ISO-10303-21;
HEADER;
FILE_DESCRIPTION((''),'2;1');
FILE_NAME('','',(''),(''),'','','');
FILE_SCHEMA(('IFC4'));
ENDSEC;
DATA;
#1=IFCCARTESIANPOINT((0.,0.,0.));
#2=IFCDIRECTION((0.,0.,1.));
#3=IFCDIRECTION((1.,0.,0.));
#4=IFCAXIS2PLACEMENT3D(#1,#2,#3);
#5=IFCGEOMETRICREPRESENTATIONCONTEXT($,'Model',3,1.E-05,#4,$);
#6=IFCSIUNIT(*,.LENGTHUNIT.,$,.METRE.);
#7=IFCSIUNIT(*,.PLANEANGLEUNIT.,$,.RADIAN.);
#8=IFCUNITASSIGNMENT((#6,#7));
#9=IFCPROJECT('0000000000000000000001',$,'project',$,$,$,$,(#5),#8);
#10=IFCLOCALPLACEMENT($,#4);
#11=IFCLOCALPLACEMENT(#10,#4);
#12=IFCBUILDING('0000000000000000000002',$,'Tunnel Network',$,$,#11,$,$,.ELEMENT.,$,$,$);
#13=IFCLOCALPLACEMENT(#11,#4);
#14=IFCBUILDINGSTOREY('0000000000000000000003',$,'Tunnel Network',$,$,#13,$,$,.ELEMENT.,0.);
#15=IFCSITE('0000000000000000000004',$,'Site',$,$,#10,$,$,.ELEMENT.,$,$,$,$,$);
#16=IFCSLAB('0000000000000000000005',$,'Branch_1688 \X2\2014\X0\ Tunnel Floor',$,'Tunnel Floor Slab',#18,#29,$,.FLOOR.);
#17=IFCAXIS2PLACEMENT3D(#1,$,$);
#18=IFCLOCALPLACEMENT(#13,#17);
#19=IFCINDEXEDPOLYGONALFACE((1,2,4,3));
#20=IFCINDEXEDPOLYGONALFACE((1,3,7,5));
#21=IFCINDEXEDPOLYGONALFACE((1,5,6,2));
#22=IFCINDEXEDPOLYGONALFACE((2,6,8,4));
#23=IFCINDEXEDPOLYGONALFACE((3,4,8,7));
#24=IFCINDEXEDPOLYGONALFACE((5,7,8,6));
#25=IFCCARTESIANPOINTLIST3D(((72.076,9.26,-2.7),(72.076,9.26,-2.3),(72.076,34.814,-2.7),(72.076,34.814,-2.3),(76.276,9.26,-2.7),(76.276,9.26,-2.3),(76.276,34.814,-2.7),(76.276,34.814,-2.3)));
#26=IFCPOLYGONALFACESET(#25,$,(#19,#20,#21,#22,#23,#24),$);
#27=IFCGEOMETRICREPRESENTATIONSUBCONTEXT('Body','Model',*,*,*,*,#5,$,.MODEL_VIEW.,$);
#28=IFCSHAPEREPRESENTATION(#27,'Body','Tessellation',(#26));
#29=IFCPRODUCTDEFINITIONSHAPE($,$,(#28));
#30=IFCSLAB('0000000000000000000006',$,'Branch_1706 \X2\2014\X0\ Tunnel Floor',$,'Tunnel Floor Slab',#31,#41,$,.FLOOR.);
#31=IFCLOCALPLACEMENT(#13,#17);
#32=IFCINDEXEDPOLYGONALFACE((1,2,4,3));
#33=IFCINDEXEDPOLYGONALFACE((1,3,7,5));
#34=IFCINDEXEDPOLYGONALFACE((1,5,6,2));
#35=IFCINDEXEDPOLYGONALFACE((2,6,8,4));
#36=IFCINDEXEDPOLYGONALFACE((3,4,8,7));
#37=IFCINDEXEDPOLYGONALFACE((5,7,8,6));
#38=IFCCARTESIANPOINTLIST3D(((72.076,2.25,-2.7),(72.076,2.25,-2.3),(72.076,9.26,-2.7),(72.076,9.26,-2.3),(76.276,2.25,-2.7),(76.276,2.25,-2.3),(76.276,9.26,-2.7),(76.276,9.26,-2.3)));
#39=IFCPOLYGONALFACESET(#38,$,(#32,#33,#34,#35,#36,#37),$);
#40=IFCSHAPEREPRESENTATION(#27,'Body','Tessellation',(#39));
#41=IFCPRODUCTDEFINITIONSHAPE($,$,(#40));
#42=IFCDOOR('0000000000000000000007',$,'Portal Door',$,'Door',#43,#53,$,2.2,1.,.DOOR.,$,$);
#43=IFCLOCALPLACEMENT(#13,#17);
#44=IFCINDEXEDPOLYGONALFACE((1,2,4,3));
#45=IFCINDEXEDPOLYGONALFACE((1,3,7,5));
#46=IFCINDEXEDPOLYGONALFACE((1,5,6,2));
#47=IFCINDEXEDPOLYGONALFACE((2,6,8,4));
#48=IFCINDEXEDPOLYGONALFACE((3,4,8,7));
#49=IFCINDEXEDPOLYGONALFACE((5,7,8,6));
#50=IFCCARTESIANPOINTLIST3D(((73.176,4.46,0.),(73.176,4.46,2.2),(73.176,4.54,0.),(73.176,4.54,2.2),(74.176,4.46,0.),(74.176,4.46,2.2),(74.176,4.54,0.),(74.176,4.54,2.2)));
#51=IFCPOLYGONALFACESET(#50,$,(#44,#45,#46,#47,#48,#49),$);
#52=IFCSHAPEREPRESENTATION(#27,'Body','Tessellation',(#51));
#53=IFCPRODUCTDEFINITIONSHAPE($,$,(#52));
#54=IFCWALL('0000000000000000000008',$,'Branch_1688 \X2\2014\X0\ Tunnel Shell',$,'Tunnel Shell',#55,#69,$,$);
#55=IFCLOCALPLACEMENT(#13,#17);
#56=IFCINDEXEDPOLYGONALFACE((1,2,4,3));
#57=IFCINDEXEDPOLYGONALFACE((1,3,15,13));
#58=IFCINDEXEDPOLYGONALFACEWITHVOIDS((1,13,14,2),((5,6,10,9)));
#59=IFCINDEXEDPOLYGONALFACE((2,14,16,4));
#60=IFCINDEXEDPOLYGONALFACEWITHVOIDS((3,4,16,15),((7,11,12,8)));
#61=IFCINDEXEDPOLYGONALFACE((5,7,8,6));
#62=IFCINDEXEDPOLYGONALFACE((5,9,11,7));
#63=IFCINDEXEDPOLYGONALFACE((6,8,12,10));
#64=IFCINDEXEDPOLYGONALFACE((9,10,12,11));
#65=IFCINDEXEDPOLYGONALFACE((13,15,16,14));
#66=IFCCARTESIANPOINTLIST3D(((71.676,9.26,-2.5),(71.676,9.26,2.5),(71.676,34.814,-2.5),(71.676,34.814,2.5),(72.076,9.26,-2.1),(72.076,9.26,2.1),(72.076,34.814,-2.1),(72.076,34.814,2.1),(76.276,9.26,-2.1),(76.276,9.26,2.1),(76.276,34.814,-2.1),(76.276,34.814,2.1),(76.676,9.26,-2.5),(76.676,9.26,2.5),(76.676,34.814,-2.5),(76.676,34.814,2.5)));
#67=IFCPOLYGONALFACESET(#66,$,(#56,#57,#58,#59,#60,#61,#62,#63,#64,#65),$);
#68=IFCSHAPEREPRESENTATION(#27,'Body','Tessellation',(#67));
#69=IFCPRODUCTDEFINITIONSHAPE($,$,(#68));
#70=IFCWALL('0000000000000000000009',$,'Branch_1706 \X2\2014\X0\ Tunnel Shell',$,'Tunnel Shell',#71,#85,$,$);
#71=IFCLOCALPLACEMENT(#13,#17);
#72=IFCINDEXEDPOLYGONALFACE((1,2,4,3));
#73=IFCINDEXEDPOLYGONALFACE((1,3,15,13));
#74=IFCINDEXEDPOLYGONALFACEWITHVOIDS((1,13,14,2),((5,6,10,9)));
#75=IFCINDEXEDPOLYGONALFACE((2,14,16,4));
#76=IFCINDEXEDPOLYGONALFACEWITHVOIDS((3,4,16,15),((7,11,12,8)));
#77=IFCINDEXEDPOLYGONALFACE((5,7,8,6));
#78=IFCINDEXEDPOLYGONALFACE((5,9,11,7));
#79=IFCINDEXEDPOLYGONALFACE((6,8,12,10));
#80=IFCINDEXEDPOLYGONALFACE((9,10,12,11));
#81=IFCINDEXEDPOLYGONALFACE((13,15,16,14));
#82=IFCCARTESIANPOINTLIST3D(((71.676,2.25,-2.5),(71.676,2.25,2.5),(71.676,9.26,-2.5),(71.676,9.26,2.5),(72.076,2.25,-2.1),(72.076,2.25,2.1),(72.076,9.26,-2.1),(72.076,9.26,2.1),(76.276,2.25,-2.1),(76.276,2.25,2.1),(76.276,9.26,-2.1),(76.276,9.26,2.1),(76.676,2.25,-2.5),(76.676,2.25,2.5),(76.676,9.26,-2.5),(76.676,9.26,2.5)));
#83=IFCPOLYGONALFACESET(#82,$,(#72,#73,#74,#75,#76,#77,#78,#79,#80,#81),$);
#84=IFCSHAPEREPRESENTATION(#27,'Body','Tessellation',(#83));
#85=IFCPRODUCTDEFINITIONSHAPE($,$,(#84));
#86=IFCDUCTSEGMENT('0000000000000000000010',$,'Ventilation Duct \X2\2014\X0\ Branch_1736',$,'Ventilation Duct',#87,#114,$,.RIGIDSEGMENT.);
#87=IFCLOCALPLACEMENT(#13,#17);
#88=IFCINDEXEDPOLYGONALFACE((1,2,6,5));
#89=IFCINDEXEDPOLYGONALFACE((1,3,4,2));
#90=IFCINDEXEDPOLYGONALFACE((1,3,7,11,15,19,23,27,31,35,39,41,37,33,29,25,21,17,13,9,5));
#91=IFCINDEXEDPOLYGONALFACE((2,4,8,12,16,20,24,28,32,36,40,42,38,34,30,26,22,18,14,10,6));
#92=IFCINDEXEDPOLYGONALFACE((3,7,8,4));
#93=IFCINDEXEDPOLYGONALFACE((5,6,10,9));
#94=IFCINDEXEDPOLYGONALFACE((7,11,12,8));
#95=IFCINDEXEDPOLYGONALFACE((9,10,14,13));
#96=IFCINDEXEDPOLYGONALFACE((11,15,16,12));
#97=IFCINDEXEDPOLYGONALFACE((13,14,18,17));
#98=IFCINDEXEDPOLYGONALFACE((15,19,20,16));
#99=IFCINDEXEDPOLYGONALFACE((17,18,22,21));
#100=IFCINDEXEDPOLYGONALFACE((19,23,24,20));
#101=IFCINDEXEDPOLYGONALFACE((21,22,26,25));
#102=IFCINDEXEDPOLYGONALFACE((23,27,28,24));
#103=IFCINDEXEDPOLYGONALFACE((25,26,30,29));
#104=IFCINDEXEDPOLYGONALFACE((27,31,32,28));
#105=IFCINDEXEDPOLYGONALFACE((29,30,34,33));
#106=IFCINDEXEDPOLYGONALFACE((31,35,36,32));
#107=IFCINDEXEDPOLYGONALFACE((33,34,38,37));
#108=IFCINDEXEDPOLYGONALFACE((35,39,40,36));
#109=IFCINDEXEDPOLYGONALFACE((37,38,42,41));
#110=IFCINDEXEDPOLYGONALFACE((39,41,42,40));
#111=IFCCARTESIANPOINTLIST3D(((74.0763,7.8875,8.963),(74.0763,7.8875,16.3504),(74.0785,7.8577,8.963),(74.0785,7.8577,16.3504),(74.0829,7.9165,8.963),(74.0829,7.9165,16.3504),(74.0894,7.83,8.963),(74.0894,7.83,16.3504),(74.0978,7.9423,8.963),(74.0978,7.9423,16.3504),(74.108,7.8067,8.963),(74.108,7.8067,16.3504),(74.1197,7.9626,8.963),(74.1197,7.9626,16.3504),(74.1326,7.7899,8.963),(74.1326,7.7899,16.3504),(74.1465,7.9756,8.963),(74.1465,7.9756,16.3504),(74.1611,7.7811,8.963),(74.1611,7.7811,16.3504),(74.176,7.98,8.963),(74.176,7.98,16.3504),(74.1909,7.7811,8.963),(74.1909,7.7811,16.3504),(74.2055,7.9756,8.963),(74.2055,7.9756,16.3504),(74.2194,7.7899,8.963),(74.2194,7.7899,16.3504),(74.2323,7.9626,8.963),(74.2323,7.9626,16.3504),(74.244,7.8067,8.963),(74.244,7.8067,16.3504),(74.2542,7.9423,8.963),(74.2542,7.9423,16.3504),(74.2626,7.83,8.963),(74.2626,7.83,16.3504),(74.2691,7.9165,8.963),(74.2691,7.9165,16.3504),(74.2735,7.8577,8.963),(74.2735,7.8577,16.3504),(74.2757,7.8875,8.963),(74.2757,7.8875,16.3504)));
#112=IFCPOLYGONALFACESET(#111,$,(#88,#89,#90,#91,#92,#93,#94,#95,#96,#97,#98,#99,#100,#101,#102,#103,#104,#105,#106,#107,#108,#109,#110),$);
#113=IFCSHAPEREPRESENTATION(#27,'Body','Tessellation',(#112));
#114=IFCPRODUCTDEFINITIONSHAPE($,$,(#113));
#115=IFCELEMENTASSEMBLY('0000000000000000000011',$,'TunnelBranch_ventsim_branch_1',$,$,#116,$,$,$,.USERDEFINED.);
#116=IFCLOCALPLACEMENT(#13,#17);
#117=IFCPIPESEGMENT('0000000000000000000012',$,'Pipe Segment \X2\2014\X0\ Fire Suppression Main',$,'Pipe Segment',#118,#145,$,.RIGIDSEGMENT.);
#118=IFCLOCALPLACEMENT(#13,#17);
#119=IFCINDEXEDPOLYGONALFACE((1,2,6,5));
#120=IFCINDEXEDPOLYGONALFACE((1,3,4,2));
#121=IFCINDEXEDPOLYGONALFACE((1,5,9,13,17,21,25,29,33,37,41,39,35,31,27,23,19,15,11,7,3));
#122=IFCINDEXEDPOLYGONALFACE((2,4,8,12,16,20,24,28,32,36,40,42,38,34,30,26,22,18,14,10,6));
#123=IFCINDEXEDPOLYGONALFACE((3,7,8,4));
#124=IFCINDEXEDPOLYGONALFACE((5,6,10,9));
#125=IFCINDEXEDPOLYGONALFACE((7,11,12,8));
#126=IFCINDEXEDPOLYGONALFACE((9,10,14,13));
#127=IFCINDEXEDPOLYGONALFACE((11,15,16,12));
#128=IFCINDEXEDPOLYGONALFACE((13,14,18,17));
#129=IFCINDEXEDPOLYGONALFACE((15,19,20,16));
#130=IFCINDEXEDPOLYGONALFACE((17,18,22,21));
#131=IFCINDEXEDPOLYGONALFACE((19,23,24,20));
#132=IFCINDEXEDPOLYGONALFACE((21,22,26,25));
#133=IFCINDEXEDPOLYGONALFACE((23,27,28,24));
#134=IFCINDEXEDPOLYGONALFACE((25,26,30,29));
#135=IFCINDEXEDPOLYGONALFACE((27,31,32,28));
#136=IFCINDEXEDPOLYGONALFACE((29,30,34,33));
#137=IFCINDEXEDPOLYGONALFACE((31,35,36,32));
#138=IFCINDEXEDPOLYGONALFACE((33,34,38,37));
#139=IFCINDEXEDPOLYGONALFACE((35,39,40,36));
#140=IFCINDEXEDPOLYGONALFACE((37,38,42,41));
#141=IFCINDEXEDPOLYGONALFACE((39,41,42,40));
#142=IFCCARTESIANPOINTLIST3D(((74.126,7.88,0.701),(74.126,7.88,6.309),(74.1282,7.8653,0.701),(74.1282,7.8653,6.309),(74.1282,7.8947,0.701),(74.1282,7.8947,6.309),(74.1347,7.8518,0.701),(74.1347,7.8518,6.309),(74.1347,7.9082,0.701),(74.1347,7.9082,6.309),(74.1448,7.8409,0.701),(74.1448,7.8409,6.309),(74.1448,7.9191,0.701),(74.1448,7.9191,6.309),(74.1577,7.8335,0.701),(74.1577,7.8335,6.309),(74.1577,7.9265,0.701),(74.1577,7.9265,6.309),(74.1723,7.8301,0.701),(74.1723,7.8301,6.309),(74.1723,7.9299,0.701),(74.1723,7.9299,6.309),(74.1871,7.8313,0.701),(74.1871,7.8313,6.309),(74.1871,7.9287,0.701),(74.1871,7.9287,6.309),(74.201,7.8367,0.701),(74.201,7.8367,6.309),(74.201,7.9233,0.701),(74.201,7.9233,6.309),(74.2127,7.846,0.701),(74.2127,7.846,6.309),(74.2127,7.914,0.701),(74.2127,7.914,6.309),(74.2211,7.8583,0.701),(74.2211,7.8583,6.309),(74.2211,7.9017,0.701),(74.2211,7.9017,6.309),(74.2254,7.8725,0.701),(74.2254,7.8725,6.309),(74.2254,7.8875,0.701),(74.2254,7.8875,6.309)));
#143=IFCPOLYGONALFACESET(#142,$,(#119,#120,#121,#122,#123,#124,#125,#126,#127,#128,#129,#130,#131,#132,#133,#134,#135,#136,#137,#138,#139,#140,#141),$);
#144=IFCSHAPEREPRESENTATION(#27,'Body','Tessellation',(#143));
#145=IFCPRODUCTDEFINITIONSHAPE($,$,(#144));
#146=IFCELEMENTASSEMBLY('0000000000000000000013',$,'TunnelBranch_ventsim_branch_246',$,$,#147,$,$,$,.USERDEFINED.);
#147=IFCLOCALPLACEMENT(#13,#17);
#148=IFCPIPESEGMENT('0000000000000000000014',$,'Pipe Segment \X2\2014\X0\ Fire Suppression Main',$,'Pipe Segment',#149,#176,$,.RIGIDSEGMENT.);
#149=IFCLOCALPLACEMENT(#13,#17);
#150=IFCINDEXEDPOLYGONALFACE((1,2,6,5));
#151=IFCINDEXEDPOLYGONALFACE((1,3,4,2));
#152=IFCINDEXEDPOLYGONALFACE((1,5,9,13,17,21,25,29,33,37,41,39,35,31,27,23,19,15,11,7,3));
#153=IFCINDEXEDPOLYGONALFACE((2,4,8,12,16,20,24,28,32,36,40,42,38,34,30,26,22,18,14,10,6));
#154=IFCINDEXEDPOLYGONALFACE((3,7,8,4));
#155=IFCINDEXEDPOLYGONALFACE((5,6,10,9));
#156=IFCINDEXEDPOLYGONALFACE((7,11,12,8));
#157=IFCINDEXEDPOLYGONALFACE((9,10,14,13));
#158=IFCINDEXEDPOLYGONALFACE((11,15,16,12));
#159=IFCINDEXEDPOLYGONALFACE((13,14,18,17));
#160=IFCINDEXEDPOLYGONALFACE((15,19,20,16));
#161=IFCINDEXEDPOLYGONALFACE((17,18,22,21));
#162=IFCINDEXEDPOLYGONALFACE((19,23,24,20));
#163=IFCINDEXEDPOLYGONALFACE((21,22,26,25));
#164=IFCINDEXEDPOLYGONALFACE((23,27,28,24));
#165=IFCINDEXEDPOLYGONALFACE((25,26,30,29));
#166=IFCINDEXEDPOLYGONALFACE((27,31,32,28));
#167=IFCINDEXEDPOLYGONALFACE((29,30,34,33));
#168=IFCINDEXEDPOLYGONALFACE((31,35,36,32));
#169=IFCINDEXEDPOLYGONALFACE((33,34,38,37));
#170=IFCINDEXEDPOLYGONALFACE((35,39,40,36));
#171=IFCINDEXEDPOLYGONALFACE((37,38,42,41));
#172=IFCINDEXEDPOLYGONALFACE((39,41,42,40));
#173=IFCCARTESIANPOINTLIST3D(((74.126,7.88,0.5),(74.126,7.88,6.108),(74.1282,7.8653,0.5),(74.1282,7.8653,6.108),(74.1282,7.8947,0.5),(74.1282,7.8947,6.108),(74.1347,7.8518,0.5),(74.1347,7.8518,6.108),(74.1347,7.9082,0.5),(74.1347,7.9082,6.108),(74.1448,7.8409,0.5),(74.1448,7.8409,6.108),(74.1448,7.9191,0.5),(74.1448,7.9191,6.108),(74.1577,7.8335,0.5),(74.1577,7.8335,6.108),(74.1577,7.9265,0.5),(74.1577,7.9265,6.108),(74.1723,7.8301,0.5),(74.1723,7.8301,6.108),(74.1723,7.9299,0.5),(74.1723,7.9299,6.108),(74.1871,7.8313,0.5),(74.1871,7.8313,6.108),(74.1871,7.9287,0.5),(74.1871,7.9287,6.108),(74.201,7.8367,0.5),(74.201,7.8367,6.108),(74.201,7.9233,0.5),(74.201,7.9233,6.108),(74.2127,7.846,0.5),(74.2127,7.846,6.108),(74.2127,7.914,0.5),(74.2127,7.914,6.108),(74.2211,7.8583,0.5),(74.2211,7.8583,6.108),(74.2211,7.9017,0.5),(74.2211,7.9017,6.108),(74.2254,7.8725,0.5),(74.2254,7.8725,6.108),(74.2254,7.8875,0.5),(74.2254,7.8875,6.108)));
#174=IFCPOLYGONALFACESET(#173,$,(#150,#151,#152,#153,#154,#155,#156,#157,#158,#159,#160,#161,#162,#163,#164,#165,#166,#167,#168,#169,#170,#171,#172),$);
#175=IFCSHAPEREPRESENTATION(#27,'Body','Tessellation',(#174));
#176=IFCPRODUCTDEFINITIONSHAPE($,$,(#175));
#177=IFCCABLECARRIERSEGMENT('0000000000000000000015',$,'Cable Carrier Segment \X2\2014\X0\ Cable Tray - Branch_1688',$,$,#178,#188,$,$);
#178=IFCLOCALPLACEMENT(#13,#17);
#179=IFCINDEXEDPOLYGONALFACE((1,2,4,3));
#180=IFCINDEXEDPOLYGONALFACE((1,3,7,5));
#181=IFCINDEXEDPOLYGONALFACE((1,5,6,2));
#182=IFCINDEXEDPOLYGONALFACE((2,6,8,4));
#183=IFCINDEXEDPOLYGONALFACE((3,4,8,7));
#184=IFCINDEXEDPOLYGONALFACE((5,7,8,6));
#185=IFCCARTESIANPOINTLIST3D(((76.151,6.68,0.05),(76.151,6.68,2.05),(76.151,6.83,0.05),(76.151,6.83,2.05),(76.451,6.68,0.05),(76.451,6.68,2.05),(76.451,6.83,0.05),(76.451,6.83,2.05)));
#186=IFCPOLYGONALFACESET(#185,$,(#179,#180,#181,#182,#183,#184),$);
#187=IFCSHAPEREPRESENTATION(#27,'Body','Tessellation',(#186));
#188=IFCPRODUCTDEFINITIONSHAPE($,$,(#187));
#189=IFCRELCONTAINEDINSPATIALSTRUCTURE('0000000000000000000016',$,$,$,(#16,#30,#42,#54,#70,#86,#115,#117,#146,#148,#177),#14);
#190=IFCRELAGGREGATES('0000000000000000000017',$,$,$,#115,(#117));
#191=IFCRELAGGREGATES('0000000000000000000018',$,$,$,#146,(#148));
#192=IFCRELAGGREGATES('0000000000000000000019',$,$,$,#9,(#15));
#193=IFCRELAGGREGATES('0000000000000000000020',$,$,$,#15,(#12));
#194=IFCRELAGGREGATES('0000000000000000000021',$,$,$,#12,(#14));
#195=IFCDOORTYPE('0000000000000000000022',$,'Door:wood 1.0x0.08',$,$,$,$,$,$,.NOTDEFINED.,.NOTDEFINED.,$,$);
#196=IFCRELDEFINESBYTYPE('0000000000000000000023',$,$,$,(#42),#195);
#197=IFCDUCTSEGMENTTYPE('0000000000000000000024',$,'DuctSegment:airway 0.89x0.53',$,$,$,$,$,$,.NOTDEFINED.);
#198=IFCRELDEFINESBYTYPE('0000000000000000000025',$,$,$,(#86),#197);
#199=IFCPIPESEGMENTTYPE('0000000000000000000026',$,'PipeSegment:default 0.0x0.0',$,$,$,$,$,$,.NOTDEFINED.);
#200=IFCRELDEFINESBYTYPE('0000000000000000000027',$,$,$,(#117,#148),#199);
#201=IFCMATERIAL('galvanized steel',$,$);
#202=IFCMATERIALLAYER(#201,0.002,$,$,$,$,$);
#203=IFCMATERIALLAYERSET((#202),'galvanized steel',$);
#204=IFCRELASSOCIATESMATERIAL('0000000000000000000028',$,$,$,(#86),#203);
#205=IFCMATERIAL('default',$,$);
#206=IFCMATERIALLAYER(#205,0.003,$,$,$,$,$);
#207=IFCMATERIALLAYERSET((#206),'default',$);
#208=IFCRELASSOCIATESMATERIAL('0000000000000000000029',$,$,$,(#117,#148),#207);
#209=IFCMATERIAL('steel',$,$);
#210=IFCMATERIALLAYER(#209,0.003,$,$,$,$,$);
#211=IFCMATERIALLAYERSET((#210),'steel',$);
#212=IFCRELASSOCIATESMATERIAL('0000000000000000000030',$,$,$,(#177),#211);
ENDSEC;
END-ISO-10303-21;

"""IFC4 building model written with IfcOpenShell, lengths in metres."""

from ifc_helpers import new_model, entity, si_unit, frame, origin_with_axes, origin_2d_with_axis, place, context, subcontext, project, spatial, rectangle, hollow_rectangle, circle, extrude, material, layer, layer_set, layer_usage, type_object, element, aggregate, save


model = new_model("IFC4")

# Units and contexts
model_context = context("Model", 3, precision=1e-05, world=origin_with_axes())
body_context = subcontext(model_context, "Body", "Model", "MODEL_VIEW")
ifc_project = project(units=[si_unit("LENGTHUNIT", "METRE"), si_unit("PLANEANGLEUNIT", "RADIAN")], contexts=[model_context])

# Site, building, storey
site_placement = place(None, origin_with_axes())
site = spatial("IfcSite", under=ifc_project, at=site_placement, Name="Site", CompositionType="ELEMENT")
building_placement = place(site_placement, origin_with_axes())
building = spatial("IfcBuilding", under=site, at=building_placement, Name="Tunnel Network", CompositionType="ELEMENT")
storey_placement = place(building_placement, origin_with_axes())
storey = spatial("IfcBuildingStorey", under=building, at=storey_placement, Name="Tunnel Network", CompositionType="ELEMENT", Elevation=0.0)

# Slabs
placement_1 = place(storey_placement, frame((74.176, 9.26, 0.0), z_axis=(0.0, 0.0, 1.0), x_axis=(0.0, 1.0, 0.0)))
element("IfcSlab", 1, at=placement_1, inside=storey, Name="Branch_1688 — Tunnel Floor", ObjectType="Tunnel Floor Slab", PredefinedType="FLOOR", context=body_context, shape_type="SweptSolid", body=[
    extrude(rectangle(XDim=0.4, YDim=4.2, at=origin_2d_with_axis()), frame((0.0, 0.0, -2.5), z_axis=(1.0, 0.0, 0.0), x_axis=(0.0, 0.0, 1.0)), (0.0, 0.0, 1.0), 25.554),
])
placement_2 = place(storey_placement, frame((74.176, 2.25, 0.0), z_axis=(0.0, 0.0, 1.0), x_axis=(0.0, 1.0, 0.0)))
element("IfcSlab", 2, at=placement_2, inside=storey, Name="Branch_1706 — Tunnel Floor", ObjectType="Tunnel Floor Slab", PredefinedType="FLOOR", context=body_context, shape_type="SweptSolid", body=[
    extrude(rectangle(XDim=0.4, YDim=4.2, at=origin_2d_with_axis()), frame((0.0, 0.0, -2.5), z_axis=(1.0, 0.0, 0.0), x_axis=(0.0, 0.0, 1.0)), (0.0, 0.0, 1.0), 7.01),
])

# Door
door_type = type_object("IfcDoorType", Name="Door:wood 1.0x0.08")
door_placement = place(storey_placement, frame((73.676, 4.5, 0.0), z_axis=(0.0, 0.0, 1.0), x_axis=(1.0, 0.0, 0.0)))
element("IfcDoor", 3, at=door_placement, inside=storey, type_object=door_type, Name="Portal Door", ObjectType="Door", OverallHeight=2.2, OverallWidth=1.0, PredefinedType="DOOR", context=body_context, shape_type="SweptSolid", body=[
    extrude(rectangle(XDim=1.0, YDim=0.08, at=origin_2d_with_axis()), origin_with_axes(), (0.0, 0.0, 1.0), 2.2),
])

# Walls
element("IfcWall", 4, at=placement_1, inside=storey, Name="Branch_1688 — Tunnel Shell", ObjectType="Tunnel Shell", context=body_context, shape_type="SweptSolid", body=[
    extrude(hollow_rectangle(XDim=5.0, YDim=5.0, WallThickness=0.4, at=origin_2d_with_axis()), frame((0.0, 0.0, 0.0), z_axis=(1.0, 0.0, 0.0), x_axis=(0.0, 0.0, 1.0)), (0.0, 0.0, 1.0), 25.554),
])
element("IfcWall", 5, at=placement_2, inside=storey, Name="Branch_1706 — Tunnel Shell", ObjectType="Tunnel Shell", context=body_context, shape_type="SweptSolid", body=[
    extrude(hollow_rectangle(XDim=5.0, YDim=5.0, WallThickness=0.4, at=origin_2d_with_axis()), frame((0.0, 0.0, 0.0), z_axis=(1.0, 0.0, 0.0), x_axis=(0.0, 0.0, 1.0)), (0.0, 0.0, 1.0), 7.01),
])

# Duct segment
ifc_material_1 = material(Name="galvanized steel")
ifc_layer_1 = layer(ifc_material_1, 0.002)
ifc_layer_set_1 = layer_set([ifc_layer_1], Name="galvanized steel")
ifc_layer_usage_1 = layer_usage(ifc_layer_set_1, "AXIS2", "POSITIVE", 0.0)
duct_segment_type = type_object("IfcDuctSegmentType", Name="DuctSegment:airway 0.89x0.53")
duct_segment_placement = place(storey_placement, frame((74.176, 7.88, 8.963), z_axis=(0.0, 0.0, 1.0), x_axis=(0.0, 1.0, 0.0)))
element("IfcDuctSegment", 6, at=duct_segment_placement, inside=storey, type_object=duct_segment_type, material=ifc_layer_usage_1, Name="Ventilation Duct — Branch_1736", ObjectType="Ventilation Duct", PredefinedType="RIGIDSEGMENT", context=body_context, shape_type="AdvancedSweptSolid", body=[
    entity("IfcSweptDiskSolid", entity("IfcPolyline", [entity("IfcCartesianPoint", [0.0, 0.0, 0.0]), entity("IfcCartesianPoint", [0.0, 0.0, 7.3874])]), 0.1),
])

# Element assemblies, pipe segments
assembly_1_placement = place(storey_placement, frame((74.176, 7.88, 0.701), z_axis=(0.0, 0.0, 1.0), x_axis=(-1.0, 0.0, 0.0)))
assembly_1 = element("IfcElementAssembly", 7, at=assembly_1_placement, inside=storey, Name="TunnelBranch_ventsim_branch_1", PredefinedType="USERDEFINED")
ifc_material_2 = material(Name="default")
ifc_layer_2 = layer(ifc_material_2, 0.003)
ifc_layer_set_2 = layer_set([ifc_layer_2], Name="default")
ifc_layer_usage_2 = layer_usage(ifc_layer_set_2, "AXIS2", "POSITIVE", 0.0)
pipe_segment_type = type_object("IfcPipeSegmentType", Name="PipeSegment:default 0.0x0.0")
pipe_segment_1_placement = place(storey_placement, frame((74.176, 7.88, 0.701), z_axis=(0.0, 0.0, 1.0), x_axis=(-1.0, 0.0, 0.0)))
pipe_segment_1 = element("IfcPipeSegment", 8, at=pipe_segment_1_placement, inside=storey, type_object=pipe_segment_type, material=ifc_layer_usage_2, Name="Pipe Segment — Fire Suppression Main", ObjectType="Pipe Segment", PredefinedType="RIGIDSEGMENT", context=body_context, shape_type="SweptSolid", body=[
    extrude(circle(Radius=0.05, at=origin_2d_with_axis()), origin_with_axes(), (0.0, 0.0, 1.0), 5.608),
])
assembly_2_placement = place(storey_placement, frame((74.176, 7.88, 0.5), z_axis=(0.0, 0.0, 1.0), x_axis=(-1.0, 0.0, 0.0)))
assembly_2 = element("IfcElementAssembly", 9, at=assembly_2_placement, inside=storey, Name="TunnelBranch_ventsim_branch_246", PredefinedType="USERDEFINED")
ifc_layer_usage_3 = layer_usage(ifc_layer_set_2, "AXIS2", "POSITIVE", 0.0)
pipe_segment_2_placement = place(storey_placement, frame((74.176, 7.88, 0.5), z_axis=(0.0, 0.0, 1.0), x_axis=(-1.0, 0.0, 0.0)))
pipe_segment_2 = element("IfcPipeSegment", 10, at=pipe_segment_2_placement, inside=storey, type_object=pipe_segment_type, material=ifc_layer_usage_3, Name="Pipe Segment — Fire Suppression Main", ObjectType="Pipe Segment", PredefinedType="RIGIDSEGMENT", context=body_context, shape_type="SweptSolid", body=[
    extrude(circle(Radius=0.05, at=origin_2d_with_axis()), origin_with_axes(), (0.0, 0.0, 1.0), 5.608),
])

# Cable carrier segment
ifc_material_3 = material(Name="steel")
ifc_layer_3 = layer(ifc_material_3, 0.003)
ifc_layer_set_3 = layer_set([ifc_layer_3], Name="steel")
ifc_layer_usage_4 = layer_usage(ifc_layer_set_3, "AXIS2", "POSITIVE", 0.0)
cable_carrier_segment_1_placement = place(storey_placement, frame((76.301, 6.755, 0.05), z_axis=(0.0, 0.0, 1.0), x_axis=(-1.0, 0.0, 0.0)))
element("IfcCableCarrierSegment", 11, at=cable_carrier_segment_1_placement, inside=storey, material=ifc_layer_usage_4, Name="Cable Carrier Segment — Cable Tray - Branch_1688", context=body_context, shape_type="SweptSolid", body=[
    extrude(rectangle(XDim=0.3, YDim=0.15, at=origin_2d_with_axis()), origin_with_axes(), (0.0, 0.0, 1.0), 2.0),
])

aggregate(assembly_1, [pipe_segment_1])

aggregate(assembly_2, [pipe_segment_2])

save(model, "model.ifc")
